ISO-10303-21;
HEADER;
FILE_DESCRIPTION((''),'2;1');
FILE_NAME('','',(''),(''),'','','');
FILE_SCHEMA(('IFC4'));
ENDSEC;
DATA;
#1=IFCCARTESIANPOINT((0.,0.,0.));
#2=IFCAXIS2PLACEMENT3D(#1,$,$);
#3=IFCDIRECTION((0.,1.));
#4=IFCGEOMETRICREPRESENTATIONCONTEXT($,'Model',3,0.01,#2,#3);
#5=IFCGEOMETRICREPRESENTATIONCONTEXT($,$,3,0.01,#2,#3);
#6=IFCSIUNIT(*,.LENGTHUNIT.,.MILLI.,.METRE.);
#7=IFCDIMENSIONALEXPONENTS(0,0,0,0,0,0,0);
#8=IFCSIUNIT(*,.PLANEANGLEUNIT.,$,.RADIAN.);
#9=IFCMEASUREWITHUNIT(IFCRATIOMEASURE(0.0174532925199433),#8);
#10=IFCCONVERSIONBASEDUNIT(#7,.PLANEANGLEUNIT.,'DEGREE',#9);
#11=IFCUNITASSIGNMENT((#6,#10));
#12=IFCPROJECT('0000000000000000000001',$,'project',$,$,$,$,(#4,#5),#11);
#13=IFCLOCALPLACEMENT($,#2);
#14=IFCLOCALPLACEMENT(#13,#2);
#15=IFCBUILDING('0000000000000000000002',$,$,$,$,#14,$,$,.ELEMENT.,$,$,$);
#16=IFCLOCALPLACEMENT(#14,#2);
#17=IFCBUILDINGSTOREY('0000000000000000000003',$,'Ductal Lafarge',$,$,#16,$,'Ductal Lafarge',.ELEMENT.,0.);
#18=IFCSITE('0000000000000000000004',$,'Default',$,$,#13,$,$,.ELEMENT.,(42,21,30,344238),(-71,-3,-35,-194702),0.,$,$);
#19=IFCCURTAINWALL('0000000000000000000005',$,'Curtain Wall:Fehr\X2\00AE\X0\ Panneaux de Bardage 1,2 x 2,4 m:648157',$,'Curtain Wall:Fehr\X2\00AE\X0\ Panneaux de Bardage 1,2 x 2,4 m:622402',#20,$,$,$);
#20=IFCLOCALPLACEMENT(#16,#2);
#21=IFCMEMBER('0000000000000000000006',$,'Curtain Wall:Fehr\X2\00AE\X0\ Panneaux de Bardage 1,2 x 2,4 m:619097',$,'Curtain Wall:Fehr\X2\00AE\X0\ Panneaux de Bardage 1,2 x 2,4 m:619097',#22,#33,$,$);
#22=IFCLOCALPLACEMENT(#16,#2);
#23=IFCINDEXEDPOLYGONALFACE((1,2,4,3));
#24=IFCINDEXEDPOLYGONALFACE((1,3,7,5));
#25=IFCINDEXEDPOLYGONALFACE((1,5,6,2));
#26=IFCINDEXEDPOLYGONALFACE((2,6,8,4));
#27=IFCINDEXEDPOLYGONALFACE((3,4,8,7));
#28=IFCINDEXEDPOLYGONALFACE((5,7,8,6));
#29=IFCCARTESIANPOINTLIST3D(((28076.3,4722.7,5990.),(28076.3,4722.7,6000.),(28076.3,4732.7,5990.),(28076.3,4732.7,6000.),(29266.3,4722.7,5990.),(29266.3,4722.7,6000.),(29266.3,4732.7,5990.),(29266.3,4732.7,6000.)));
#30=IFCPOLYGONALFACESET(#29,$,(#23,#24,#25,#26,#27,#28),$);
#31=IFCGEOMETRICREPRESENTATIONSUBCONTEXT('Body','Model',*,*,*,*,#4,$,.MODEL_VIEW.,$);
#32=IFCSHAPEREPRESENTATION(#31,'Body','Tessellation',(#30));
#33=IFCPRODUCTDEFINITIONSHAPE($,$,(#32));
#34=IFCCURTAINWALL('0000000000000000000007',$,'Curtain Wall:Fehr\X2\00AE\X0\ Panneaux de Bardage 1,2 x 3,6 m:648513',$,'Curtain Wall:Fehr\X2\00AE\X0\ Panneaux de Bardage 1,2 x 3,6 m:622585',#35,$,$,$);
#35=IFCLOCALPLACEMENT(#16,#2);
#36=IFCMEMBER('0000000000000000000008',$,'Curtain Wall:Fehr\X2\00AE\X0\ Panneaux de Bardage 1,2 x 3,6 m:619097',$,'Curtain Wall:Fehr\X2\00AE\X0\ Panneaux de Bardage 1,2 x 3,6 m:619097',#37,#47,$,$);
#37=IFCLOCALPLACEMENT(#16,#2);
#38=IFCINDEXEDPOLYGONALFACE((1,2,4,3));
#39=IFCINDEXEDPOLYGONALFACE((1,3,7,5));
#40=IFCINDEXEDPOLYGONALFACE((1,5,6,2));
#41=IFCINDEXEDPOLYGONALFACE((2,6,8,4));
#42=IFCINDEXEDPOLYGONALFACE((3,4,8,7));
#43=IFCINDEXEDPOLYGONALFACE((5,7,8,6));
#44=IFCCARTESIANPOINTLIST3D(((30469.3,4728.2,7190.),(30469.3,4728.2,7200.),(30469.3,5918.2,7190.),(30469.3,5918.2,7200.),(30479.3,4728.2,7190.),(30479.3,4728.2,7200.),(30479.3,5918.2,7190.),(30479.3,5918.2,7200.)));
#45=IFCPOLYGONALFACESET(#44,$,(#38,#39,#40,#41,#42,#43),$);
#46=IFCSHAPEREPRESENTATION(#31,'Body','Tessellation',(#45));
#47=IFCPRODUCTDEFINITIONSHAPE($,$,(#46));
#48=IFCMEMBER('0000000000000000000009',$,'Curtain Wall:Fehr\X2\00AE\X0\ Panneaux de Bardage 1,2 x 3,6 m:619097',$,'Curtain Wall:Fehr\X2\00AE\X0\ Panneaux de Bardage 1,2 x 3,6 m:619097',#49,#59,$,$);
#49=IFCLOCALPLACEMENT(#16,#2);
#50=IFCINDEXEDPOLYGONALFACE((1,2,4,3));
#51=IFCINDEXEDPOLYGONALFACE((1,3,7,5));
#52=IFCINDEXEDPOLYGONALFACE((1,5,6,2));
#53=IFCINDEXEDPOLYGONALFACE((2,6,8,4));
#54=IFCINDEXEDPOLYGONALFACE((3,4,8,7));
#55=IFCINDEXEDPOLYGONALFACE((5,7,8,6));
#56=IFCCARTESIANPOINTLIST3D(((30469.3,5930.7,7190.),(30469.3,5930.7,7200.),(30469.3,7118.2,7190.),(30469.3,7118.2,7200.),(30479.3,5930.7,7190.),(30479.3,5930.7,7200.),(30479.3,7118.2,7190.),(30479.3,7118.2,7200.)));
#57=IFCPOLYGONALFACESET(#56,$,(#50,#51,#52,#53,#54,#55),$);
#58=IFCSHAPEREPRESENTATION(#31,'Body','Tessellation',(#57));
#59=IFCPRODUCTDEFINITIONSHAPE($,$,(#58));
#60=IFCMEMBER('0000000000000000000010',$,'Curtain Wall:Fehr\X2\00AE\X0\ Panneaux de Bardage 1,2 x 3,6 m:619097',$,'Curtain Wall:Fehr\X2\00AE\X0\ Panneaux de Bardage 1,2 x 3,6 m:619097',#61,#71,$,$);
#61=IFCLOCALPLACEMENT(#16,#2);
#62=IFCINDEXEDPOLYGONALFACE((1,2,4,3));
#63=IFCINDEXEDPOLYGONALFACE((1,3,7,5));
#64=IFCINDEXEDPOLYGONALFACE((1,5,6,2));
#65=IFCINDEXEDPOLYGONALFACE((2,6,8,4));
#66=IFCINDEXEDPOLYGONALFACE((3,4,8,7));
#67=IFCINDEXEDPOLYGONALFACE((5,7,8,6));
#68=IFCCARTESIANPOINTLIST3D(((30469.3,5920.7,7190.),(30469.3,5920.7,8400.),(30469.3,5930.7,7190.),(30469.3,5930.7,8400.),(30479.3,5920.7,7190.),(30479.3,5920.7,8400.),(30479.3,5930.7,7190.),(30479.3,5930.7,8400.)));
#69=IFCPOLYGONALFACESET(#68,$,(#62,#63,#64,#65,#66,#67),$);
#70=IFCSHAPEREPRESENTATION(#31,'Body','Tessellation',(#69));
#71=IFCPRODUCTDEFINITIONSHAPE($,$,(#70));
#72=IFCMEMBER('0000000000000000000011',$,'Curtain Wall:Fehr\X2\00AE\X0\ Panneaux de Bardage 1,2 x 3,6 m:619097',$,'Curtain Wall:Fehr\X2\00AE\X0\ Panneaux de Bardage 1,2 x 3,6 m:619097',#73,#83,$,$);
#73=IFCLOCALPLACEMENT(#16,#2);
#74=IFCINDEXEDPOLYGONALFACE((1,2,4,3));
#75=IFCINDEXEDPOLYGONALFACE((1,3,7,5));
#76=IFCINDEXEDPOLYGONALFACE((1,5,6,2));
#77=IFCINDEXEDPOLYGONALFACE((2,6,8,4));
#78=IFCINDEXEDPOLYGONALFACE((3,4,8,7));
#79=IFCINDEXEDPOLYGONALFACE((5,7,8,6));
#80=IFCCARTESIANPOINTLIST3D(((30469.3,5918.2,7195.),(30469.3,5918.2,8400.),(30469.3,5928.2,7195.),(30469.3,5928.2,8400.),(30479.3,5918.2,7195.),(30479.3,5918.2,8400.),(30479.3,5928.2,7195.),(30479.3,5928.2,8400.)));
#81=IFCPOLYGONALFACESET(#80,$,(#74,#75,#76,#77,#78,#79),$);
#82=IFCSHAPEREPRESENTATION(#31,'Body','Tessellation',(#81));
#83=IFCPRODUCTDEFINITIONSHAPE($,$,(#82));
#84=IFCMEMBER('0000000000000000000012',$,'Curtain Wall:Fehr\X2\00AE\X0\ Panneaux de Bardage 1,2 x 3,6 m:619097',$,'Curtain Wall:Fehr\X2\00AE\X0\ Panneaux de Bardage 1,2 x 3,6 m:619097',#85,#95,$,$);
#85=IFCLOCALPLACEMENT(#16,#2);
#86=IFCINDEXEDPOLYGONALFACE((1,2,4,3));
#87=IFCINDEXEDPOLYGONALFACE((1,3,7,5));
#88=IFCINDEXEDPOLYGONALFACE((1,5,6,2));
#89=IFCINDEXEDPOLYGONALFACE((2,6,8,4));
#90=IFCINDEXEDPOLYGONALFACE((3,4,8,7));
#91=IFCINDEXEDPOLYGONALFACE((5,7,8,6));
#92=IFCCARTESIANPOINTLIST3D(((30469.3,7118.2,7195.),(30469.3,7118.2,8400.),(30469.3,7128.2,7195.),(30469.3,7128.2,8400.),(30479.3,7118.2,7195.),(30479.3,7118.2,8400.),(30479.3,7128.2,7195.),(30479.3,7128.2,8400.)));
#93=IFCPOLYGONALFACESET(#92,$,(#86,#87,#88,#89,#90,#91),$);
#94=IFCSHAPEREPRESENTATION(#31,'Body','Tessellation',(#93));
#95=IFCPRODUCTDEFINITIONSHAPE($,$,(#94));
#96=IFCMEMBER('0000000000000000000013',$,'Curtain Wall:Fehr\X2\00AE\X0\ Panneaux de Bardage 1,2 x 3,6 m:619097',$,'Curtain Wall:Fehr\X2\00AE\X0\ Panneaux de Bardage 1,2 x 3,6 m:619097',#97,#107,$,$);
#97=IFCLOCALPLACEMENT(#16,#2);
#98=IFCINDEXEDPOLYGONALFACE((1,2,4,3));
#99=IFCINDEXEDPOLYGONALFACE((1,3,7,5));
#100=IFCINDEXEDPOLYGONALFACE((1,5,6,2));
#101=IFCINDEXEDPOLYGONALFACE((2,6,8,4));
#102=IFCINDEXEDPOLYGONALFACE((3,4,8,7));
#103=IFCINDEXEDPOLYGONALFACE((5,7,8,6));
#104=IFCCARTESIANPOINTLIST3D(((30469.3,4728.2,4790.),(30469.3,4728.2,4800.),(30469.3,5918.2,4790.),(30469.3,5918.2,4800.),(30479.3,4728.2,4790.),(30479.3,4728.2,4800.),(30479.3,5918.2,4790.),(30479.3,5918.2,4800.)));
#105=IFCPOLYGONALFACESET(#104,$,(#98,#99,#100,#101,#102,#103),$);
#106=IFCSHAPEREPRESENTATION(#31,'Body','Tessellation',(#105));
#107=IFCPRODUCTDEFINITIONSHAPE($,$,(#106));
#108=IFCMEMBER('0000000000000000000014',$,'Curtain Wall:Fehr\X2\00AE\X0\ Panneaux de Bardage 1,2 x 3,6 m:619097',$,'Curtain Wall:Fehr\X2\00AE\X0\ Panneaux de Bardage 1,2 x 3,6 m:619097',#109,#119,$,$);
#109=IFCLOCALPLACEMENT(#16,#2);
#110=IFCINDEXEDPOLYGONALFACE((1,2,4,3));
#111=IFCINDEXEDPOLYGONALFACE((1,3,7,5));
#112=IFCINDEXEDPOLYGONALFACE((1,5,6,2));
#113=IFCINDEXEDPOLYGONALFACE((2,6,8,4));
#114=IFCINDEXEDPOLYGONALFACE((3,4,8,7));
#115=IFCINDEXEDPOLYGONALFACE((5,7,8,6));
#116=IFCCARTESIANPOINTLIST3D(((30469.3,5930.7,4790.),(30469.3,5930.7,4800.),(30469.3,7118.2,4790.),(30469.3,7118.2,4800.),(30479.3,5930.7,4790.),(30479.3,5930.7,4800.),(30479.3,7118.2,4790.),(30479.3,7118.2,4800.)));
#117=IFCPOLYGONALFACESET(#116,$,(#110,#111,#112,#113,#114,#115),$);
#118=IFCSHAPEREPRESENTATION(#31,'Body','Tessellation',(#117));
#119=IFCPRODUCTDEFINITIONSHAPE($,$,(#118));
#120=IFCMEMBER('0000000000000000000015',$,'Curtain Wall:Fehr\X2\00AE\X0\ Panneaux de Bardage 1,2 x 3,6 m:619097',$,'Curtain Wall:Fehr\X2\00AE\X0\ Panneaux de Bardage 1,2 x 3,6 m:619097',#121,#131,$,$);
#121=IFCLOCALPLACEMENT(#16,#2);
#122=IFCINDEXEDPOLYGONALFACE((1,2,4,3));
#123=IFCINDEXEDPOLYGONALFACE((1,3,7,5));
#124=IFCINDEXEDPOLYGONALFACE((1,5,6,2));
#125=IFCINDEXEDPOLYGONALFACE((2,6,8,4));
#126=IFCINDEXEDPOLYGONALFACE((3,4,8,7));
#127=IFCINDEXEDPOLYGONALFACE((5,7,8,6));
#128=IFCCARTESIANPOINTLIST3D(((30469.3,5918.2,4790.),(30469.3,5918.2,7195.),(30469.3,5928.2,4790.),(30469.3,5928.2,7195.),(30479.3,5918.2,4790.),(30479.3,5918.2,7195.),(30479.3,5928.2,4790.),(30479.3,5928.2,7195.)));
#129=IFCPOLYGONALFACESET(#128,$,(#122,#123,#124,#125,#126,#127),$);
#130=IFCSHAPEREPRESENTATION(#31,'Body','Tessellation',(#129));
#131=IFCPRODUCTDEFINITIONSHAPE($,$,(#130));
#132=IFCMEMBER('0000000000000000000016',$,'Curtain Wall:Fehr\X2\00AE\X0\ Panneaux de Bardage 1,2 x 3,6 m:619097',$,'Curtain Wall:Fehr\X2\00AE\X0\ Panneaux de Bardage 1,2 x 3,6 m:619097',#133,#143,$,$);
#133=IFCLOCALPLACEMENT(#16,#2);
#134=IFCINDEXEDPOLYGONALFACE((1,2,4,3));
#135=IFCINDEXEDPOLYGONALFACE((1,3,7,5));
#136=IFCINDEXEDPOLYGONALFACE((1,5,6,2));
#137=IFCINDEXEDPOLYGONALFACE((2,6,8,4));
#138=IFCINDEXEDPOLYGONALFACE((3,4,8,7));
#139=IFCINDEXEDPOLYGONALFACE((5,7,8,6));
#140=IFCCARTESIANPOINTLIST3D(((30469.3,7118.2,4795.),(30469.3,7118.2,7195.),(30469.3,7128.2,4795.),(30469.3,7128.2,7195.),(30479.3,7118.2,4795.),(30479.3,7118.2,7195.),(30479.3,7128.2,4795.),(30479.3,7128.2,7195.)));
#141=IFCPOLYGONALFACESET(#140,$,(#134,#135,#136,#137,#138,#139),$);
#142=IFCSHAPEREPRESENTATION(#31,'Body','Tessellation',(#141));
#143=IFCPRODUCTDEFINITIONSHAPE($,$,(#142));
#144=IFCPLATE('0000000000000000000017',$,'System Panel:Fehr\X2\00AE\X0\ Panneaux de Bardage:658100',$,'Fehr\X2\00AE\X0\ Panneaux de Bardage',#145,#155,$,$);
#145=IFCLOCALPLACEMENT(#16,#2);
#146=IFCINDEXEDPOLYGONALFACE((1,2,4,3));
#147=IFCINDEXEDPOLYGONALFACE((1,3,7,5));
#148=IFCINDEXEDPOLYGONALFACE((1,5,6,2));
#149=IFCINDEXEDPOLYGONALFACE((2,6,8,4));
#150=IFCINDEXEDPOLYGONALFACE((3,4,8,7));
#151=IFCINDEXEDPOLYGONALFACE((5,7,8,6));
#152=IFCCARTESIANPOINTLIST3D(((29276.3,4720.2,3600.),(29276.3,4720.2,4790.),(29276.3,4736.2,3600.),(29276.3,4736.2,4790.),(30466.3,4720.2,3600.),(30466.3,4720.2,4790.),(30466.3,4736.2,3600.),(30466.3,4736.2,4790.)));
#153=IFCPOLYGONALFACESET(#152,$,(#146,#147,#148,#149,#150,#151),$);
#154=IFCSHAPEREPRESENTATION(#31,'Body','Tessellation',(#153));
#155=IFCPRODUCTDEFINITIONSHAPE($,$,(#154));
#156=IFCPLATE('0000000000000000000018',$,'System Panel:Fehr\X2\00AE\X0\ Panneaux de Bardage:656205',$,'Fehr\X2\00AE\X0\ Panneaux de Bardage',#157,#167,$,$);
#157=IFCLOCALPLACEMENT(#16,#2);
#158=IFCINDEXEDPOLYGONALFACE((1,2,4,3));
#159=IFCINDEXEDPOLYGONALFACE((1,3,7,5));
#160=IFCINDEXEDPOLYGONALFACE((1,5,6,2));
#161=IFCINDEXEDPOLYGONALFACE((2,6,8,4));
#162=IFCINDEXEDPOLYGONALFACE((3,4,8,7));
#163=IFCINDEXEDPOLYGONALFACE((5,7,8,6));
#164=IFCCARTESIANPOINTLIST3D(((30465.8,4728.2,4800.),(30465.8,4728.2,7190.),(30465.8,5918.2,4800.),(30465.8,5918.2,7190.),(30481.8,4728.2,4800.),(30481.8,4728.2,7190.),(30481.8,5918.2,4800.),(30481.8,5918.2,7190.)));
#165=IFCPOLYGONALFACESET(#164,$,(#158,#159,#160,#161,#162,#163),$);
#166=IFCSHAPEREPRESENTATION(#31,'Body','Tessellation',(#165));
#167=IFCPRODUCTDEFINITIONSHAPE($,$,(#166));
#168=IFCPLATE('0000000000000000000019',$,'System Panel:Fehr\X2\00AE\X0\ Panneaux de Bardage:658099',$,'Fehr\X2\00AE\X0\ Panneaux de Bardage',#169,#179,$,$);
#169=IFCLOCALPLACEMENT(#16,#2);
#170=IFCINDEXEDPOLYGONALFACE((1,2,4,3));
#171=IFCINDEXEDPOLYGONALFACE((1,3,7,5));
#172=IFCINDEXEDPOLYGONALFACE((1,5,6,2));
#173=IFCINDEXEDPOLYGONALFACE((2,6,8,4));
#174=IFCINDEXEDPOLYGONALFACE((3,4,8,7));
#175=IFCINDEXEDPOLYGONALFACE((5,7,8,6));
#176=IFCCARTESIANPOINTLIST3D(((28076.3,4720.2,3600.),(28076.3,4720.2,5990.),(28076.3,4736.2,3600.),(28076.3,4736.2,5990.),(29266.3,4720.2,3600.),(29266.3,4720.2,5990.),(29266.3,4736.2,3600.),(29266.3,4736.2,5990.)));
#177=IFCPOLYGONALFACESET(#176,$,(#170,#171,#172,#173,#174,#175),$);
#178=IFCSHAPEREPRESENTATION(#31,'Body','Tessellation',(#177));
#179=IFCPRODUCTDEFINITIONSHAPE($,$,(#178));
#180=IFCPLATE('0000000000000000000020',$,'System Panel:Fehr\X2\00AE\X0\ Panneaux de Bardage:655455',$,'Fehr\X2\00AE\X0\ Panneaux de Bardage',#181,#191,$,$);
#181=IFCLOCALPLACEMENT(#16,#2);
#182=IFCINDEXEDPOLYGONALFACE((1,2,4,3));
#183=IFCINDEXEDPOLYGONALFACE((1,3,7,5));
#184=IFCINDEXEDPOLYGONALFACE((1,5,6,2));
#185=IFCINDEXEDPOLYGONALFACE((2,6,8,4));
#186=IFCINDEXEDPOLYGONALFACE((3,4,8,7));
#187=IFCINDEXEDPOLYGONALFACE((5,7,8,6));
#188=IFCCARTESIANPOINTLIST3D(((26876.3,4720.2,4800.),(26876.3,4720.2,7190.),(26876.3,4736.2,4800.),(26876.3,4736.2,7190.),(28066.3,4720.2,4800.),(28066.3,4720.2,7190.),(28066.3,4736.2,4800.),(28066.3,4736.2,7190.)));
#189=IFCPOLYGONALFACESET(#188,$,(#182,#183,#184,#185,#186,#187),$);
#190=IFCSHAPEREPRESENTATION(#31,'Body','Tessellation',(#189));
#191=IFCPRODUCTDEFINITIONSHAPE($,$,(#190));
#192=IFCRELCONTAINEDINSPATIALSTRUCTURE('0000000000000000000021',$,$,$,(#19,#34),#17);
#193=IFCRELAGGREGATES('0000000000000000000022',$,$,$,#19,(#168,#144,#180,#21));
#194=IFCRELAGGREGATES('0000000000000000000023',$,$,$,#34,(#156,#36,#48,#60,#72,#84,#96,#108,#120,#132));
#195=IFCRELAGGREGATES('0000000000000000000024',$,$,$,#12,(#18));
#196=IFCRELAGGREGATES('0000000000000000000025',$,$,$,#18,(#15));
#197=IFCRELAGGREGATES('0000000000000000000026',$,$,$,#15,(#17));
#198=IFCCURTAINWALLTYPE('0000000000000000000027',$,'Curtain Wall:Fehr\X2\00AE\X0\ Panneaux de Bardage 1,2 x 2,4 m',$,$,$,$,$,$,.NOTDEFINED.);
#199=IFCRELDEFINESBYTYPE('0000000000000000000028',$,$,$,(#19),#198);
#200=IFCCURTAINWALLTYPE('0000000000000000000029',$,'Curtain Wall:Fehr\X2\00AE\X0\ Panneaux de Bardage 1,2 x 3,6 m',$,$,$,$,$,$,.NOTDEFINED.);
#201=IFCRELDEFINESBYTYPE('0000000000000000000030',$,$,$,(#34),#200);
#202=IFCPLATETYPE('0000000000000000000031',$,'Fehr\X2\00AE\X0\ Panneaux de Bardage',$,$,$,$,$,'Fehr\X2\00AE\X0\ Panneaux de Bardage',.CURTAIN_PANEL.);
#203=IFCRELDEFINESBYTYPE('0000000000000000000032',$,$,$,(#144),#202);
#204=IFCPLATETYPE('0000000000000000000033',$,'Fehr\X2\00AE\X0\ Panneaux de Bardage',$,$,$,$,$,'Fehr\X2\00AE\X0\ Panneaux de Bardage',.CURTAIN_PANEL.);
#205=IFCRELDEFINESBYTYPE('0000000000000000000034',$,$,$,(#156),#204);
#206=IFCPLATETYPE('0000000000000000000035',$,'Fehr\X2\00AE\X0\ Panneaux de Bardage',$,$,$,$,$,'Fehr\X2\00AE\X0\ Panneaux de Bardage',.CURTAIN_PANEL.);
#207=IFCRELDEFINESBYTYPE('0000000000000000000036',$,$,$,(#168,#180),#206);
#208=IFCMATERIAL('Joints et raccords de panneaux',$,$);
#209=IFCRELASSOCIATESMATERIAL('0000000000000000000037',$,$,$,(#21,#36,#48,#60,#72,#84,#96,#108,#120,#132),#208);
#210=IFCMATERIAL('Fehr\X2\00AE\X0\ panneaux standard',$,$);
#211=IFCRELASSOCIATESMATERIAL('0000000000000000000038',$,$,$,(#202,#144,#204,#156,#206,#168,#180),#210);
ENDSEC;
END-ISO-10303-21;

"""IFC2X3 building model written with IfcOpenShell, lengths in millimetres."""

from ifc_helpers import new_model, entity, si_unit, converted_unit, direction, frame, frame_2d, origin, origin_2d_with_axis, place, context, subcontext, project, spatial, rectangle, extrude, source, transform, mapped, material, type_object, type_shapes, element, aggregate, save


model = new_model("IFC2X3")

# Units and contexts
model_context = context("Model", 3, precision=0.01, world=origin(), true_north=direction((0.0, 1.0)))
context_of_model = context(None, 3, precision=0.01, world=origin(), true_north=direction((0.0, 1.0)))
body_context = subcontext(model_context, "Body", "Model", "MODEL_VIEW")
ifc_project = project(units=[si_unit("LENGTHUNIT", "METRE", prefix="MILLI"), converted_unit("PLANEANGLEUNIT", "DEGREE", entity("IfcRatioMeasure", 0.0174532925199433), si_unit("PLANEANGLEUNIT", "RADIAN"), dimensions=[0, 0, 0, 0, 0, 0, 0])], contexts=[model_context, context_of_model])

# Site, building, storey
site_placement = place(None, origin())
site = spatial("IfcSite", under=ifc_project, at=site_placement, Name="Default", CompositionType="ELEMENT", RefLatitude=(42, 21, 30, 344238), RefLongitude=(-71, -3, -35, -194702), RefElevation=0.0)
building_placement = place(site_placement, origin())
building = spatial("IfcBuilding", under=site, at=building_placement, CompositionType="ELEMENT")
storey_placement = place(building_placement, origin())
storey = spatial("IfcBuildingStorey", under=building, at=storey_placement, Name="Ductal Lafarge", LongName="Ductal Lafarge", CompositionType="ELEMENT", Elevation=0.0)

# Curtain walls, members
curtain_wall_type_1 = type_object("IfcCurtainWallType", Name="Curtain Wall:Fehr® Panneaux de Bardage 1,2 x 2,4 m", PredefinedType="NOTDEFINED")
curtain_wall_1_placement = place(storey_placement, origin())
curtain_wall_1 = element("IfcCurtainWall", 1, at=curtain_wall_1_placement, inside=storey, type_object=curtain_wall_type_1, Name="Curtain Wall:Fehr® Panneaux de Bardage 1,2 x 2,4 m:648157", ObjectType="Curtain Wall:Fehr® Panneaux de Bardage 1,2 x 2,4 m:622402")
ifc_material_1 = material(Name="Joints et raccords de panneaux")
member_1_placement = place(curtain_wall_1_placement, frame((28076.3, 4722.7, 5990.0)))
member_1 = element("IfcMember", 2, at=member_1_placement, material=ifc_material_1, Name="Curtain Wall:Fehr® Panneaux de Bardage 1,2 x 2,4 m:619097", ObjectType="Curtain Wall:Fehr® Panneaux de Bardage 1,2 x 2,4 m:619097", context=body_context, shape_type="SweptSolid", body=[
    extrude(rectangle(XDim=1190.0, YDim=10.0, at=frame_2d((0.0, 0.0), x_axis=(1.0, 0.0))), frame((595.0, 5.0, 0.0), z_axis=(0.0, 0.0, 1.0), x_axis=(-1.0, 0.0, 0.0)), (0.0, 0.0, 1.0), 10.0),
])
curtain_wall_type_2 = type_object("IfcCurtainWallType", Name="Curtain Wall:Fehr® Panneaux de Bardage 1,2 x 3,6 m", PredefinedType="NOTDEFINED")
curtain_wall_2_placement = place(storey_placement, origin())
curtain_wall_2 = element("IfcCurtainWall", 3, at=curtain_wall_2_placement, inside=storey, type_object=curtain_wall_type_2, Name="Curtain Wall:Fehr® Panneaux de Bardage 1,2 x 3,6 m:648513", ObjectType="Curtain Wall:Fehr® Panneaux de Bardage 1,2 x 3,6 m:622585")
member_2_placement = place(curtain_wall_2_placement, frame((30469.3, 4728.2, 7190.0)))
member_2 = element("IfcMember", 4, at=member_2_placement, material=ifc_material_1, Name="Curtain Wall:Fehr® Panneaux de Bardage 1,2 x 3,6 m:619097", ObjectType="Curtain Wall:Fehr® Panneaux de Bardage 1,2 x 3,6 m:619097", context=body_context, shape_type="SweptSolid", body=[
    extrude(rectangle(XDim=1190.0, YDim=10.0, at=frame_2d((0.0, 0.0), x_axis=(1.0, 0.0))), frame((5.0, 595.0, 0.0), z_axis=(0.0, 0.0, 1.0), x_axis=(0.0, -1.0, 0.0)), (0.0, 0.0, 1.0), 10.0),
])
member_3_placement = place(curtain_wall_2_placement, frame((30469.3, 5930.7, 7190.0)))
member_3 = element("IfcMember", 5, at=member_3_placement, material=ifc_material_1, Name="Curtain Wall:Fehr® Panneaux de Bardage 1,2 x 3,6 m:619097", ObjectType="Curtain Wall:Fehr® Panneaux de Bardage 1,2 x 3,6 m:619097", context=body_context, shape_type="SweptSolid", body=[
    extrude(rectangle(XDim=1187.5, YDim=10.0, at=frame_2d((0.0, 0.0), x_axis=(1.0, 0.0))), frame((5.0, 593.8, 0.0), z_axis=(0.0, 0.0, 1.0), x_axis=(0.0, -1.0, 0.0)), (0.0, 0.0, 1.0), 10.0),
])
member_4_placement = place(curtain_wall_2_placement, frame((30469.3, 5920.7, 7190.0)))
member_4 = element("IfcMember", 6, at=member_4_placement, material=ifc_material_1, Name="Curtain Wall:Fehr® Panneaux de Bardage 1,2 x 3,6 m:619097", ObjectType="Curtain Wall:Fehr® Panneaux de Bardage 1,2 x 3,6 m:619097", context=body_context, shape_type="SweptSolid", body=[
    extrude(rectangle(XDim=10.0, YDim=10.0, at=frame_2d((0.0, 0.0), x_axis=(1.0, 0.0))), frame((5.0, 5.0, 0.0), z_axis=(0.0, 0.0, 1.0), x_axis=(-1.0, 0.0, 0.0)), (0.0, 0.0, 1.0), 1210.0),
])
member_5_placement = place(curtain_wall_2_placement, frame((30469.3, 5918.2, 7195.0)))
member_5 = element("IfcMember", 7, at=member_5_placement, material=ifc_material_1, Name="Curtain Wall:Fehr® Panneaux de Bardage 1,2 x 3,6 m:619097", ObjectType="Curtain Wall:Fehr® Panneaux de Bardage 1,2 x 3,6 m:619097", context=body_context, shape_type="SweptSolid", body=[
    extrude(rectangle(XDim=10.0, YDim=10.0, at=frame_2d((0.0, 0.0), x_axis=(1.0, 0.0))), frame((5.0, 5.0, 0.0), z_axis=(0.0, 0.0, 1.0), x_axis=(-1.0, 0.0, 0.0)), (0.0, 0.0, 1.0), 1205.0),
])
member_6_placement = place(curtain_wall_2_placement, frame((30469.3, 7118.2, 7195.0)))
member_6 = element("IfcMember", 8, at=member_6_placement, material=ifc_material_1, Name="Curtain Wall:Fehr® Panneaux de Bardage 1,2 x 3,6 m:619097", ObjectType="Curtain Wall:Fehr® Panneaux de Bardage 1,2 x 3,6 m:619097", context=body_context, shape_type="SweptSolid", body=[
    extrude(rectangle(XDim=10.0, YDim=10.0, at=frame_2d((0.0, 0.0), x_axis=(1.0, 0.0))), frame((5.0, 5.0, 0.0), z_axis=(0.0, 0.0, 1.0), x_axis=(-1.0, 0.0, 0.0)), (0.0, 0.0, 1.0), 1205.0),
])
member_7_placement = place(curtain_wall_2_placement, frame((30469.3, 4728.2, 4790.0)))
member_7 = element("IfcMember", 9, at=member_7_placement, material=ifc_material_1, Name="Curtain Wall:Fehr® Panneaux de Bardage 1,2 x 3,6 m:619097", ObjectType="Curtain Wall:Fehr® Panneaux de Bardage 1,2 x 3,6 m:619097", context=body_context, shape_type="SweptSolid", body=[
    extrude(rectangle(XDim=1190.0, YDim=10.0, at=frame_2d((0.0, 0.0), x_axis=(1.0, 0.0))), frame((5.0, 595.0, 0.0), z_axis=(0.0, 0.0, 1.0), x_axis=(0.0, -1.0, 0.0)), (0.0, 0.0, 1.0), 10.0),
])
member_8_placement = place(curtain_wall_2_placement, frame((30469.3, 5930.7, 4790.0)))
member_8 = element("IfcMember", 10, at=member_8_placement, material=ifc_material_1, Name="Curtain Wall:Fehr® Panneaux de Bardage 1,2 x 3,6 m:619097", ObjectType="Curtain Wall:Fehr® Panneaux de Bardage 1,2 x 3,6 m:619097", context=body_context, shape_type="SweptSolid", body=[
    extrude(rectangle(XDim=1187.5, YDim=10.0, at=frame_2d((0.0, 0.0), x_axis=(1.0, 0.0))), frame((5.0, 593.8, 0.0), z_axis=(0.0, 0.0, 1.0), x_axis=(0.0, -1.0, 0.0)), (0.0, 0.0, 1.0), 10.0),
])
member_9_placement = place(curtain_wall_2_placement, frame((30469.3, 5918.2, 4790.0)))
member_9 = element("IfcMember", 11, at=member_9_placement, material=ifc_material_1, Name="Curtain Wall:Fehr® Panneaux de Bardage 1,2 x 3,6 m:619097", ObjectType="Curtain Wall:Fehr® Panneaux de Bardage 1,2 x 3,6 m:619097", context=body_context, shape_type="SweptSolid", body=[
    extrude(rectangle(XDim=10.0, YDim=10.0, at=frame_2d((0.0, 0.0), x_axis=(1.0, 0.0))), frame((5.0, 5.0, 0.0), z_axis=(0.0, 0.0, 1.0), x_axis=(-1.0, 0.0, 0.0)), (0.0, 0.0, 1.0), 2405.0),
])
member_10_placement = place(curtain_wall_2_placement, frame((30469.3, 7118.2, 4795.0)))
member_10 = element("IfcMember", 12, at=member_10_placement, material=ifc_material_1, Name="Curtain Wall:Fehr® Panneaux de Bardage 1,2 x 3,6 m:619097", ObjectType="Curtain Wall:Fehr® Panneaux de Bardage 1,2 x 3,6 m:619097", context=body_context, shape_type="SweptSolid", body=[
    extrude(rectangle(XDim=10.0, YDim=10.0, at=frame_2d((0.0, 0.0), x_axis=(1.0, 0.0))), frame((5.0, 5.0, 0.0), z_axis=(0.0, 0.0, 1.0), x_axis=(-1.0, 0.0, 0.0)), (0.0, 0.0, 1.0), 2400.0),
])

# Plates
ifc_material_2 = material(Name="Fehr® panneaux standard")
plate_type_1 = type_object("IfcPlateType", Name="Fehr® Panneaux de Bardage", ElementType="Fehr® Panneaux de Bardage", PredefinedType="CURTAIN_PANEL", material=ifc_material_2)
shared_shape_1 = source(origin(), body_context, "Body", "SweptSolid", [
    extrude(rectangle(XDim=16.0, YDim=1190.0, at=origin_2d_with_axis()), frame((0.0, 0.0, 0.0), z_axis=(0.0, 0.0, 1.0), x_axis=(0.0, 1.0, 0.0)), (0.0, 0.0, 1.0), 1190.0),
])
type_shapes(plate_type_1, [shared_shape_1])
plate_1_placement = place(curtain_wall_1_placement, frame((29871.3, 4728.2, 3600.0)))
plate_1 = element("IfcPlate", 13, at=plate_1_placement, type_object=plate_type_1, material=ifc_material_2, Name="System Panel:Fehr® Panneaux de Bardage:658100", ObjectType="Fehr® Panneaux de Bardage", context=body_context, shape_type="MappedRepresentation", body=[
    mapped(shared_shape_1, transform((0.0, 0.0, 0.0), scale=1.0)),
])
plate_type_2 = type_object("IfcPlateType", Name="Fehr® Panneaux de Bardage", ElementType="Fehr® Panneaux de Bardage", PredefinedType="CURTAIN_PANEL", material=ifc_material_2)
shared_shape_2 = source(origin(), body_context, "Body", "SweptSolid", [
    extrude(rectangle(XDim=16.0, YDim=1190.0, at=origin_2d_with_axis()), frame((0.0, 0.0, 0.0), z_axis=(0.0, 0.0, 1.0), x_axis=(0.0, 1.0, 0.0)), (0.0, 0.0, 1.0), 2390.0),
])
type_shapes(plate_type_2, [shared_shape_2])
plate_2_placement = place(curtain_wall_2_placement, frame((30473.8, 5323.2, 4800.0), z_axis=(0.0, 0.0, 1.0), x_axis=(0.0, 1.0, 0.0)))
plate_2 = element("IfcPlate", 14, at=plate_2_placement, type_object=plate_type_2, material=ifc_material_2, Name="System Panel:Fehr® Panneaux de Bardage:656205", ObjectType="Fehr® Panneaux de Bardage", context=body_context, shape_type="MappedRepresentation", body=[
    mapped(shared_shape_2, transform((0.0, 0.0, 0.0), scale=1.0)),
])
plate_type_3 = type_object("IfcPlateType", Name="Fehr® Panneaux de Bardage", ElementType="Fehr® Panneaux de Bardage", PredefinedType="CURTAIN_PANEL", material=ifc_material_2)
shared_shape_3 = source(origin(), body_context, "Body", "SweptSolid", [
    extrude(rectangle(XDim=2390.0, YDim=1190.0, at=origin_2d_with_axis()), frame((0.0, -8.0, 1195.0), z_axis=(0.0, 1.0, 0.0), x_axis=(0.0, 0.0, 1.0)), (0.0, 0.0, 1.0), 16.0),
])
type_shapes(plate_type_3, [shared_shape_3])
plate_3_placement = place(curtain_wall_1_placement, frame((28671.3, 4728.2, 3600.0)))
plate_3 = element("IfcPlate", 15, at=plate_3_placement, type_object=plate_type_3, material=ifc_material_2, Name="System Panel:Fehr® Panneaux de Bardage:658099", ObjectType="Fehr® Panneaux de Bardage", context=body_context, shape_type="MappedRepresentation", body=[
    mapped(shared_shape_3, transform((0.0, 0.0, 0.0), scale=1.0)),
])
plate_4_placement = place(curtain_wall_1_placement, frame((27471.3, 4728.2, 4800.0)))
plate_4 = element("IfcPlate", 16, at=plate_4_placement, type_object=plate_type_3, material=ifc_material_2, Name="System Panel:Fehr® Panneaux de Bardage:655455", ObjectType="Fehr® Panneaux de Bardage", context=body_context, shape_type="MappedRepresentation", body=[
    mapped(shared_shape_3, transform((0.0, 0.0, 0.0), scale=1.0)),
])
aggregate(curtain_wall_1, [plate_3, plate_1, plate_4, member_1])
aggregate(curtain_wall_2, [plate_2, member_2, member_3, member_4, member_5, member_6, member_7, member_8, member_9, member_10])

save(model, "model.ifc")
